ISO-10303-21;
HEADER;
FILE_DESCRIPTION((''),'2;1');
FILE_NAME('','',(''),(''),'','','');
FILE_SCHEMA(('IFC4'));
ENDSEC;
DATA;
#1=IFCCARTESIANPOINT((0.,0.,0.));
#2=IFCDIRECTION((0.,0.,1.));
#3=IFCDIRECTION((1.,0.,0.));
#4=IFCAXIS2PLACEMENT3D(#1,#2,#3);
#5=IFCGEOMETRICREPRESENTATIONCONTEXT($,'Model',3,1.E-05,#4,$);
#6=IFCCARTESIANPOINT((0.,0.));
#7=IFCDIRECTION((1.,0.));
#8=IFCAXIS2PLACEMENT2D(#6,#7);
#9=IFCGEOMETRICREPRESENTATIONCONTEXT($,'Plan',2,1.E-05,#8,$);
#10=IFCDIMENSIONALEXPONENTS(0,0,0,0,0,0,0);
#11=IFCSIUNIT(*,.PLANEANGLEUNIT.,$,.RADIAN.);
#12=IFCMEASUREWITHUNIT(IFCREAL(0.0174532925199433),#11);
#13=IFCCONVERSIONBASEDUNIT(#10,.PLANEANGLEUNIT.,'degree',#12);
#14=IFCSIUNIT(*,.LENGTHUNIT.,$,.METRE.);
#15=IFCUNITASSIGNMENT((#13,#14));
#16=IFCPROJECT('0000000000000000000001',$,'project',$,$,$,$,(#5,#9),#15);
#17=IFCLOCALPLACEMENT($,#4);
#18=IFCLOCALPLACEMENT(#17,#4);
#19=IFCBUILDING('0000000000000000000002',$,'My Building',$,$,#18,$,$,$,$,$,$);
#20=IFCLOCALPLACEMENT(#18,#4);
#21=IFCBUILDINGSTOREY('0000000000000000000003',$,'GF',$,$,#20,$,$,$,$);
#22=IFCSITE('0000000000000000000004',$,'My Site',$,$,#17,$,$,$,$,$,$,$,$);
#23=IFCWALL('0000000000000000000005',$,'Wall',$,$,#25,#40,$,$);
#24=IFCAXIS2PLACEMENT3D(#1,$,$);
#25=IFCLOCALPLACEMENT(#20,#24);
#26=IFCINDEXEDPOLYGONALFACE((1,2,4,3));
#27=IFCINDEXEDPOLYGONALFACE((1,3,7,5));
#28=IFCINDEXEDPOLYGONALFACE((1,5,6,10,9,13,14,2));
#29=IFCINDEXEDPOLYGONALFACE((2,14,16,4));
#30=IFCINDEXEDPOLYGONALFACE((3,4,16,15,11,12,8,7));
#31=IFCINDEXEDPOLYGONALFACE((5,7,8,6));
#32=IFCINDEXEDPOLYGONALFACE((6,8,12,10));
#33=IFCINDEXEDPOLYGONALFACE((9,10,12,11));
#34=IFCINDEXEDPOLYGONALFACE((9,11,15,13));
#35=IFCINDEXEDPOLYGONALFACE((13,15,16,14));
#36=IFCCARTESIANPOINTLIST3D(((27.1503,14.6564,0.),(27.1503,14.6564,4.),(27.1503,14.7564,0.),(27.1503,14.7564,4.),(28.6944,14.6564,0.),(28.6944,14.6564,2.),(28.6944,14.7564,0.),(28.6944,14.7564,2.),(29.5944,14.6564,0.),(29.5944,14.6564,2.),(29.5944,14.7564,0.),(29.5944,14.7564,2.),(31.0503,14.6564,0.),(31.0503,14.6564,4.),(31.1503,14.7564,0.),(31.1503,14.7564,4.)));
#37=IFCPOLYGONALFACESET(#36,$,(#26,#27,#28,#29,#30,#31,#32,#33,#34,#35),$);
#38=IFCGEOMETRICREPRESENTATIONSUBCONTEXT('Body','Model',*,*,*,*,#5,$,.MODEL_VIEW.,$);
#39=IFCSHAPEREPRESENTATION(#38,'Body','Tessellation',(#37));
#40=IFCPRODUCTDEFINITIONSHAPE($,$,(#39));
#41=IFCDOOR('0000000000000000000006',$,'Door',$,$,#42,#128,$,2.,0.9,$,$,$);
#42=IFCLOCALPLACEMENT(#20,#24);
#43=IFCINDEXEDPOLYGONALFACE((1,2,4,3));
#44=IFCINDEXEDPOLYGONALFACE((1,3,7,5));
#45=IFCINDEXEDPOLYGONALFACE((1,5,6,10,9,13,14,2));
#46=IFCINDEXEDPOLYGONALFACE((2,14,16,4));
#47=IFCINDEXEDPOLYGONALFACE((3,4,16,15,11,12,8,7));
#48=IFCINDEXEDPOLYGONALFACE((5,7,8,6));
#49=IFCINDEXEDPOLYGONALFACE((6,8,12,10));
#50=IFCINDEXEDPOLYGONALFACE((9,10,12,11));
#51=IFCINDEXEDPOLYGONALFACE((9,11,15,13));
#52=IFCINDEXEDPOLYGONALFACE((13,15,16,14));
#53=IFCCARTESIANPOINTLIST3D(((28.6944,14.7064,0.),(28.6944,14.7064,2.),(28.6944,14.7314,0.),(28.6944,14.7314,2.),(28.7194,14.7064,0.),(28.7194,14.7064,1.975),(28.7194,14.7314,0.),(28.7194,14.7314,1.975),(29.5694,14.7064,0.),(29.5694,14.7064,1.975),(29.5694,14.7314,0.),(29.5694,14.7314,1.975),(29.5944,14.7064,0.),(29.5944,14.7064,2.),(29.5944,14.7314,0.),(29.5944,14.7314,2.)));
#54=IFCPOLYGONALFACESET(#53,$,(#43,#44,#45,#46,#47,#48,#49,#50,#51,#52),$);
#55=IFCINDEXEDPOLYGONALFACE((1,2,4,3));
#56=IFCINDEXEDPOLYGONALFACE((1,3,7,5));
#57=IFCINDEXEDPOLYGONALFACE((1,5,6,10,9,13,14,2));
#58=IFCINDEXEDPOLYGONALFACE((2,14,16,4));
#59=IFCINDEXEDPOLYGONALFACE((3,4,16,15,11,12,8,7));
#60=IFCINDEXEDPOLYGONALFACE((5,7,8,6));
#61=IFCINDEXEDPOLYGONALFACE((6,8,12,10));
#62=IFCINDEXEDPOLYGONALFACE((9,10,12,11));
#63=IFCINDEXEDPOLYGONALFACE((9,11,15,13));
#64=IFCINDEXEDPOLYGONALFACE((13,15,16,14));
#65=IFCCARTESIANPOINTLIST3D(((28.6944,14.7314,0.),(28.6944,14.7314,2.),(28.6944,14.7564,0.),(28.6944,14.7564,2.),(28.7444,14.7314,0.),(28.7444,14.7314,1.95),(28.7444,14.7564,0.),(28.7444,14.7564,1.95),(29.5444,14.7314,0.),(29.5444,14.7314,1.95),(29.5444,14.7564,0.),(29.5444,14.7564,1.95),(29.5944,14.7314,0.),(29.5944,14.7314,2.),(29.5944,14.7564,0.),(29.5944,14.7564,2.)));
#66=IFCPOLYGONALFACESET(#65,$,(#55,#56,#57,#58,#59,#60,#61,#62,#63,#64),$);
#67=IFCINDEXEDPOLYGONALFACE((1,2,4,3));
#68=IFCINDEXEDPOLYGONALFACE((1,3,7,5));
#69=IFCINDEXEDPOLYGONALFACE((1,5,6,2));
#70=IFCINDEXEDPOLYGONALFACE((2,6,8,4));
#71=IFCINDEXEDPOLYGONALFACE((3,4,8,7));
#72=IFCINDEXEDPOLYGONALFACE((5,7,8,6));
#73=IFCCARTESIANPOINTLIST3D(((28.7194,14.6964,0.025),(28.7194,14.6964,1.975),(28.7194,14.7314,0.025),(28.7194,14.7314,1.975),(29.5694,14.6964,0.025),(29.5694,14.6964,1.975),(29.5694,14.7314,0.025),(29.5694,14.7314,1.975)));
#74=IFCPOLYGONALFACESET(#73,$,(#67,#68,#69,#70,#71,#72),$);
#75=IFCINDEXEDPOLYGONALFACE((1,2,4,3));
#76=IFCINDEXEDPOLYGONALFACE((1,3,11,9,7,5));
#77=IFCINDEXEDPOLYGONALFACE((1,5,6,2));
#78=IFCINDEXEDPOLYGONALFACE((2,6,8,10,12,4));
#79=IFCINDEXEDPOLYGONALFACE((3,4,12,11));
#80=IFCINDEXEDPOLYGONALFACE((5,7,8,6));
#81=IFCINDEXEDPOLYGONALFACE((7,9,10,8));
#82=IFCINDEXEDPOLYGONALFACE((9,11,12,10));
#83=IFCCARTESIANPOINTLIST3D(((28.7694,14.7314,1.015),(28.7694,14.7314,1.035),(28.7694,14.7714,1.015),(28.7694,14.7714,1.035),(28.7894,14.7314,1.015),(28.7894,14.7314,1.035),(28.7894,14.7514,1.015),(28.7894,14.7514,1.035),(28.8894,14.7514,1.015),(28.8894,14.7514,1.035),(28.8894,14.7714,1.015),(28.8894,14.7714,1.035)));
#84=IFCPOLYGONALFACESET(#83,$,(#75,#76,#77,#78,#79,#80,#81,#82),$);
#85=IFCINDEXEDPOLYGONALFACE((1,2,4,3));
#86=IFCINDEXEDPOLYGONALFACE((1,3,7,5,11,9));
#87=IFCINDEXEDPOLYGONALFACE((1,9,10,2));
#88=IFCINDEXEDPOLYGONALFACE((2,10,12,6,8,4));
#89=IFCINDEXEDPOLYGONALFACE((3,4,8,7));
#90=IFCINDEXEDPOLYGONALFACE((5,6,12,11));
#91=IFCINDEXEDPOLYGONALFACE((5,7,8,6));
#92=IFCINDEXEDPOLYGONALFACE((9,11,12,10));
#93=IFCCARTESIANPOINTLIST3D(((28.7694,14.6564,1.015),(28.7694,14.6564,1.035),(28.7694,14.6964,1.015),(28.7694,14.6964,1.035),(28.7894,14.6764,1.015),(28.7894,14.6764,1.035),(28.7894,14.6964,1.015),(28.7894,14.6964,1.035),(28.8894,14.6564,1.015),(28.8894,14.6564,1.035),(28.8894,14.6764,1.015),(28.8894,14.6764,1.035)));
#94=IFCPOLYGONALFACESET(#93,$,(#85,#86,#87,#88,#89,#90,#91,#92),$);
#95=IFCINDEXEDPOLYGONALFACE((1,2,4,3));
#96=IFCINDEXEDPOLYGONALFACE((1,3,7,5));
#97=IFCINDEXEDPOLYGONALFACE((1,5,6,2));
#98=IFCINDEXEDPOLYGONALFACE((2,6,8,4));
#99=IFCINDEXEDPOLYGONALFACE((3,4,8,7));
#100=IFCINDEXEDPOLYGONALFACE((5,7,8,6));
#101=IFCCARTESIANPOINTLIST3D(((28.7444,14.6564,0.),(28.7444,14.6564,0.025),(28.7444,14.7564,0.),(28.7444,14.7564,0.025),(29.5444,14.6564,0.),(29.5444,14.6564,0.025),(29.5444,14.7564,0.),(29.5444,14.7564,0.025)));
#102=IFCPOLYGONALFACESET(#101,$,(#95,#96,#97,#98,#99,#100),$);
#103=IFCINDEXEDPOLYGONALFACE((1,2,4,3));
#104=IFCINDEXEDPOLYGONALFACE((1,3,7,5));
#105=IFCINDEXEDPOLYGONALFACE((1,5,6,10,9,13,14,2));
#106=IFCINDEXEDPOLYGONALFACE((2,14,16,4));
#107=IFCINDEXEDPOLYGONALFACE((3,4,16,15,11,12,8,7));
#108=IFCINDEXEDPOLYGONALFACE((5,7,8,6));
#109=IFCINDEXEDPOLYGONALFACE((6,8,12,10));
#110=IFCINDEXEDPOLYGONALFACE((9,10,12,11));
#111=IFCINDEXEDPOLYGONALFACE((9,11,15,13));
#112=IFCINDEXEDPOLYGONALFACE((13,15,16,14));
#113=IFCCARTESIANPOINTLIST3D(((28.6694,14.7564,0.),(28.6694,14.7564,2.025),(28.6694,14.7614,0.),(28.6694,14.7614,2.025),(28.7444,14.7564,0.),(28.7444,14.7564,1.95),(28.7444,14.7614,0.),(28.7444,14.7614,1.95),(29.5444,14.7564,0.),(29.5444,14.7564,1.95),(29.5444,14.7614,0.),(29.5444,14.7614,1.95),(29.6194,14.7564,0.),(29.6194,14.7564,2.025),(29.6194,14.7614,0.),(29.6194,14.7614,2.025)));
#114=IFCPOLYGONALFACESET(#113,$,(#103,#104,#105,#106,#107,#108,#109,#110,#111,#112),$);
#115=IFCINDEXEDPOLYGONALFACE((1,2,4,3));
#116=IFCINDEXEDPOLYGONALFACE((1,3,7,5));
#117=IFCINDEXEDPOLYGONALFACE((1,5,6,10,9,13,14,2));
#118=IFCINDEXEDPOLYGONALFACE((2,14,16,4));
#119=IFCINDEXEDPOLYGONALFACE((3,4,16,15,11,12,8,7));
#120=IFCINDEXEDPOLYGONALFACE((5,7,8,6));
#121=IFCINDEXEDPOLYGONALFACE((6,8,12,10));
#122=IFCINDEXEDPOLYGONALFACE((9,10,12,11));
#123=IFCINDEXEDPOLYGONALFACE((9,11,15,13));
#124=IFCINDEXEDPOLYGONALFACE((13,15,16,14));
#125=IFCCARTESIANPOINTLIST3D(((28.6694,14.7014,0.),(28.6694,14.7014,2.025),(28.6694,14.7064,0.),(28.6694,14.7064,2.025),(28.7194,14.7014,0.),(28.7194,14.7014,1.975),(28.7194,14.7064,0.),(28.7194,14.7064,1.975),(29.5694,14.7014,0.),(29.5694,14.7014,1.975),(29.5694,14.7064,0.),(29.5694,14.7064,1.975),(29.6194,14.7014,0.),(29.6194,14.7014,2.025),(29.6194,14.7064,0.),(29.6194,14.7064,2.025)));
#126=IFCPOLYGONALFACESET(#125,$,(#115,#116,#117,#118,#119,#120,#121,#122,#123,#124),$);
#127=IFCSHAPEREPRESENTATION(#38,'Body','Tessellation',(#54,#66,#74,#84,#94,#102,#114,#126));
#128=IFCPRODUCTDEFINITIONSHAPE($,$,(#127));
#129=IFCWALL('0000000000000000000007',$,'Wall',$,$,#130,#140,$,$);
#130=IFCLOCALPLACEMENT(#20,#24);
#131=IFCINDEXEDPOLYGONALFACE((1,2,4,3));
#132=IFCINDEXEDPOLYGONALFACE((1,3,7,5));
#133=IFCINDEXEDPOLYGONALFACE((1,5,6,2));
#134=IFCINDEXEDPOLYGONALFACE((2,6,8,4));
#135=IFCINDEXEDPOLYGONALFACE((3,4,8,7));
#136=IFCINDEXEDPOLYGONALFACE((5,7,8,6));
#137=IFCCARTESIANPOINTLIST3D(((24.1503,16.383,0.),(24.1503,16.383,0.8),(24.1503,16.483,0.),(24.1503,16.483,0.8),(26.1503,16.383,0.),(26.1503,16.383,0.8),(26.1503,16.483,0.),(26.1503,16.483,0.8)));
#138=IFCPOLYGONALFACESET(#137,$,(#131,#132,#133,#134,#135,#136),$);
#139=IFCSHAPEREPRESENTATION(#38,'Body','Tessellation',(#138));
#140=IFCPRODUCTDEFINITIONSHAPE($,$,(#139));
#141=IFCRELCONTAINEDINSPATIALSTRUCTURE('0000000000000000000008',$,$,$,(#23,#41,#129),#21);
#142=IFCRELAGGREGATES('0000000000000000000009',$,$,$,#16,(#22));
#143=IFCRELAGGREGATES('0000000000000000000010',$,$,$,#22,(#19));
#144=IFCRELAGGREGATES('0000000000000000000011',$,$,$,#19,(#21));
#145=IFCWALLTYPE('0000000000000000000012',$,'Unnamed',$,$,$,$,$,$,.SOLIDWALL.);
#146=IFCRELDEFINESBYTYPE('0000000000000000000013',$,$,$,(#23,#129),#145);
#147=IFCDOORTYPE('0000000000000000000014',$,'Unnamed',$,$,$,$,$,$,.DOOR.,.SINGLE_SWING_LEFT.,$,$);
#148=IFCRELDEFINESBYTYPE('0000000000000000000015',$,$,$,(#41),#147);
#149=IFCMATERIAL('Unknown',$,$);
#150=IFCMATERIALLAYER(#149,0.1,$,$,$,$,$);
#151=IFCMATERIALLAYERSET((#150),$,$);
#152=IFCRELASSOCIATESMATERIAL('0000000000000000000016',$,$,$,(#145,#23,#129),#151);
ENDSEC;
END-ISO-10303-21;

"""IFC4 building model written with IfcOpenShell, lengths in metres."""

from ifc_helpers import new_model, entity, si_unit, converted_unit, frame, origin_with_axes, origin_2d_with_axis, place, context, subcontext, project, spatial, line, indexed_curve, outline, extrude, shape, source, transform, mapped, material, layer, layer_set, layer_usage, type_object, type_shapes, element, fill, save


model = new_model("IFC4")

# Units and contexts
model_context = context("Model", 3, precision=1e-05, world=origin_with_axes())
plan_context = context("Plan", 2, precision=1e-05, world=origin_2d_with_axis())
body_context_1 = subcontext(model_context, "Body", "Model", "MODEL_VIEW")
body_context_2 = subcontext(plan_context, "Body", "Plan", "PLAN_VIEW")
ifc_project = project(units=[converted_unit("PLANEANGLEUNIT", "degree", entity("IfcReal", 0.0174532925199433), si_unit("PLANEANGLEUNIT", "RADIAN"), dimensions=[0, 0, 0, 0, 0, 0, 0]), si_unit("LENGTHUNIT", "METRE")], contexts=[model_context, plan_context])

# Site, building, storey
site_placement = place(None, origin_with_axes())
site = spatial("IfcSite", under=ifc_project, at=site_placement, Name="My Site")
building_placement = place(site_placement, origin_with_axes())
building = spatial("IfcBuilding", under=site, at=building_placement, Name="My Building")
storey_placement = place(building_placement, origin_with_axes())
storey = spatial("IfcBuildingStorey", under=building, at=storey_placement, Name="GF")

# Shared definitions
ifc_material = material(Name="Unknown")

# Shared definitions
ifc_layer_1 = layer(ifc_material, 0.1)
ifc_layer_set_1 = layer_set([ifc_layer_1])
wall_type = type_object("IfcWallType", Name="Unnamed", PredefinedType="SOLIDWALL", material=ifc_layer_set_1)
shared_shape_1 = source(origin_with_axes(), body_context_1, "Body", "SweptSolid", [
    extrude(outline(indexed_curve([(0.0, 0.0), (0.9, 0.0), (0.9, 2.0), (0.0, 2.0)], segments=[line(1, 2, 3, 4, 1)])), frame((0.0, -0.6, 0.0), z_axis=(0.0, -1.0, 0.0), x_axis=(1.0, 0.0, 0.0)), (0.0, 0.0, -1.0), 1.2),
])
door_type = type_object("IfcDoorType", Name="Unnamed", OperationType="SINGLE_SWING_LEFT", PredefinedType="DOOR")
shared_shape_2 = source(origin_with_axes(), body_context_1, "Body", "SweptSolid", [
    extrude(outline(indexed_curve([(0.0, 0.0), (0.0, 2.0), (0.9, 2.0), (0.9, 0.0), (0.875, 0.0), (0.875, 1.975), (0.025, 1.975), (0.025, 0.0)], segments=[line(1, 2, 3, 4, 5, 6, 7, 8, 1)])), frame((0.0, 0.025, 0.0), z_axis=(0.0, -1.0, 0.0), x_axis=(1.0, 0.0, 0.0)), (0.0, 0.0, -1.0), 0.025),
    extrude(outline(indexed_curve([(0.0, 0.0), (0.0, 2.0), (0.9, 2.0), (0.9, 0.0), (0.85, 0.0), (0.85, 1.95), (0.05, 1.95), (0.05, 0.0)], segments=[line(1, 2, 3, 4, 5, 6, 7, 8, 1)])), frame((0.0, 0.0, 0.0), z_axis=(0.0, -1.0, 0.0), x_axis=(1.0, 0.0, 0.0)), (0.0, 0.0, -1.0), 0.025),
    extrude(outline(indexed_curve([(0.0, 0.0), (0.85, 0.0), (0.85, 0.035), (0.0, 0.035)], segments=[line(1, 2, 3, 4, 1)])), frame((0.025, 0.025, 0.025), z_axis=(0.0, 0.0, 1.0), x_axis=(1.0, 0.0, 0.0)), (0.0, 0.0, 1.0), 1.95),
    extrude(outline(indexed_curve([(0.0, 0.0), (0.0, -0.04), (-0.12, -0.04), (-0.12, -0.02), (-0.02, -0.02), (-0.02, 0.0)], segments=[line(1, 2, 3, 4, 5, 6, 1)])), frame((0.825, 0.025, 1.015), z_axis=(0.0, 0.0, 1.0), x_axis=(1.0, 0.0, 0.0)), (0.0, 0.0, 1.0), 0.02),
    extrude(outline(indexed_curve([(0.0, 0.0), (0.0, 0.04), (-0.12, 0.04), (-0.12, 0.02), (-0.02, 0.02), (-0.02, 0.0)], segments=[line(1, 2, 3, 4, 5, 6, 1)])), frame((0.825, 0.06, 1.015), z_axis=(0.0, 0.0, 1.0), x_axis=(1.0, 0.0, 0.0)), (0.0, 0.0, 1.0), 0.02),
    extrude(outline(indexed_curve([(0.0, 0.0), (0.8, 0.0), (0.8, 0.1), (0.0, 0.1)], segments=[line(1, 2, 3, 4, 1)])), frame((0.05, 0.0, 0.0), z_axis=(0.0, 0.0, 1.0), x_axis=(1.0, 0.0, 0.0)), (0.0, 0.0, 1.0), 0.025),
    extrude(outline(indexed_curve([(0.0, 0.0), (0.0, 2.025), (0.95, 2.025), (0.95, 0.0), (0.875, 0.0), (0.875, 1.95), (0.075, 1.95), (0.075, 0.0)], segments=[line(1, 2, 3, 4, 5, 6, 7, 8, 1)])), frame((-0.025, -0.005, 0.0), z_axis=(0.0, -1.0, 0.0), x_axis=(1.0, 0.0, 0.0)), (0.0, 0.0, -1.0), 0.005),
    extrude(outline(indexed_curve([(0.0, 0.0), (0.0, 2.025), (0.95, 2.025), (0.95, 0.0), (0.9, 0.0), (0.9, 1.975), (0.05, 1.975), (0.05, 0.0)], segments=[line(1, 2, 3, 4, 5, 6, 7, 8, 1)])), frame((-0.025, 0.05, 0.0), z_axis=(0.0, -1.0, 0.0), x_axis=(1.0, 0.0, 0.0)), (0.0, 0.0, -1.0), 0.005),
])
shared_shape_3 = source(origin_with_axes(), body_context_2, "Body", "Curve2D", [
    entity("IfcIndexedPolyCurve", entity("IfcCartesianPointList2D", [[0.0, 0.0], [0.0, 0.05], [0.025, 0.05], [0.025, 0.025], [0.05, 0.025], [0.05, 0.0]]), [entity("IfcLineIndex", [1, 2, 3, 4, 5, 6, 1])]),
    entity("IfcIndexedPolyCurve", entity("IfcCartesianPointList2D", [[0.9, 0.0], [0.9, 0.05], [0.875, 0.05], [0.875, 0.025], [0.85, 0.025], [0.85, 0.0]]), [entity("IfcLineIndex", [1, 2, 3, 4, 5, 6, 1])]),
    entity("IfcTrimmedCurve", entity("IfcEllipse", entity("IfcAxis2Placement2D", entity("IfcCartesianPoint", [0.06, 0.05]), entity("IfcDirection", [1.0, 0.0])), 0.815, 0.85), [entity("IfcCartesianPoint", [0.875, 0.05])], [entity("IfcCartesianPoint", [0.06, 0.9])], True, "CARTESIAN"),
    entity("IfcIndexedPolyCurve", entity("IfcCartesianPointList2D", [[0.025, 0.05], [0.06, 0.05], [0.06, 0.9], [0.025, 0.9]]), [entity("IfcLineIndex", [1, 2, 3, 4, 1])]),
])
type_shapes(door_type, [shared_shape_2, shared_shape_3])

# Wall, opening, door
ifc_layer_usage_1 = layer_usage(ifc_layer_set_1, "AXIS2", "POSITIVE", 0.0)
wall_1_placement = place(storey_placement, frame((31.1503, 14.7564, 0.0), z_axis=(0.0, 0.0, 1.0), x_axis=(-1.0, 0.0, 0.0)))
wall_1 = element("IfcWall", 1, at=wall_1_placement, inside=storey, type_object=wall_type, material=ifc_layer_usage_1, Name="Wall", context=body_context_1, shape_type="SweptSolid", body=[
    extrude(outline(indexed_curve([(0.0, 0.0), (0.1, 0.1), (4.0, 0.1), (4.0, 0.0)], segments=[line(1, 2, 3, 4, 1)])), origin_with_axes(), (0.0, 0.0, 1.0), 4.0),
])
opening_1_placement = place(wall_1_placement, frame((1.556, 0.0, 0.0), z_axis=(0.0, 0.0, 1.0), x_axis=(1.0, 0.0, 0.0)))
opening_1 = element("IfcOpeningElement", 2, at=opening_1_placement, cuts=wall_1, PredefinedType="OPENING", context=body_context_1, shape_type="MappedRepresentation", body=[
    mapped(shared_shape_1, transform((0.0, 0.0, 0.0), x_axis=(1.0, 0.0, 0.0), y_axis=(0.0, 1.0, 0.0), z_axis=(0.0, 0.0, 1.0), scale=1.0)),
])
door_1_placement = place(opening_1_placement, frame((0.0, 0.0, 0.0), z_axis=(0.0, 0.0, 1.0), x_axis=(1.0, 0.0, 0.0)))
door_1 = element("IfcDoor", 3, at=door_1_placement, inside=storey, type_object=door_type, Name="Door", OverallHeight=2.0, OverallWidth=0.9, shapes=[
    shape(body_context_1, "Body", "MappedRepresentation", [mapped(shared_shape_2, transform((0.0, 0.0, 0.0), x_axis=(1.0, 0.0, 0.0), y_axis=(0.0, 1.0, 0.0), z_axis=(0.0, 0.0, 1.0), scale=1.0))]),
    shape(body_context_2, "Body", "MappedRepresentation", [mapped(shared_shape_3, transform((0.0, 0.0, 0.0), x_axis=(1.0, 0.0, 0.0), y_axis=(0.0, 1.0, 0.0), z_axis=(0.0, 0.0, 1.0), scale=1.0))]),
])
fill(opening_1, door_1)

# Wall
ifc_layer_usage_2 = layer_usage(ifc_layer_set_1, "AXIS2", "POSITIVE", 0.0)
wall_2_placement = place(storey_placement, frame((24.1503, 16.383, 0.0), z_axis=(0.0, 0.0, 1.0), x_axis=(1.0, 0.0, 0.0)))
element("IfcWall", 4, at=wall_2_placement, inside=storey, type_object=wall_type, material=ifc_layer_usage_2, Name="Wall", context=body_context_1, shape_type="SweptSolid", body=[
    extrude(outline(indexed_curve([(0.0, 0.0), (0.0, 0.1), (2.0, 0.1), (2.0, 0.0)], segments=[line(1, 2, 3, 4, 1)])), origin_with_axes(), (0.0, 0.0, 1.0), 0.8),
])

save(model, "model.ifc")
